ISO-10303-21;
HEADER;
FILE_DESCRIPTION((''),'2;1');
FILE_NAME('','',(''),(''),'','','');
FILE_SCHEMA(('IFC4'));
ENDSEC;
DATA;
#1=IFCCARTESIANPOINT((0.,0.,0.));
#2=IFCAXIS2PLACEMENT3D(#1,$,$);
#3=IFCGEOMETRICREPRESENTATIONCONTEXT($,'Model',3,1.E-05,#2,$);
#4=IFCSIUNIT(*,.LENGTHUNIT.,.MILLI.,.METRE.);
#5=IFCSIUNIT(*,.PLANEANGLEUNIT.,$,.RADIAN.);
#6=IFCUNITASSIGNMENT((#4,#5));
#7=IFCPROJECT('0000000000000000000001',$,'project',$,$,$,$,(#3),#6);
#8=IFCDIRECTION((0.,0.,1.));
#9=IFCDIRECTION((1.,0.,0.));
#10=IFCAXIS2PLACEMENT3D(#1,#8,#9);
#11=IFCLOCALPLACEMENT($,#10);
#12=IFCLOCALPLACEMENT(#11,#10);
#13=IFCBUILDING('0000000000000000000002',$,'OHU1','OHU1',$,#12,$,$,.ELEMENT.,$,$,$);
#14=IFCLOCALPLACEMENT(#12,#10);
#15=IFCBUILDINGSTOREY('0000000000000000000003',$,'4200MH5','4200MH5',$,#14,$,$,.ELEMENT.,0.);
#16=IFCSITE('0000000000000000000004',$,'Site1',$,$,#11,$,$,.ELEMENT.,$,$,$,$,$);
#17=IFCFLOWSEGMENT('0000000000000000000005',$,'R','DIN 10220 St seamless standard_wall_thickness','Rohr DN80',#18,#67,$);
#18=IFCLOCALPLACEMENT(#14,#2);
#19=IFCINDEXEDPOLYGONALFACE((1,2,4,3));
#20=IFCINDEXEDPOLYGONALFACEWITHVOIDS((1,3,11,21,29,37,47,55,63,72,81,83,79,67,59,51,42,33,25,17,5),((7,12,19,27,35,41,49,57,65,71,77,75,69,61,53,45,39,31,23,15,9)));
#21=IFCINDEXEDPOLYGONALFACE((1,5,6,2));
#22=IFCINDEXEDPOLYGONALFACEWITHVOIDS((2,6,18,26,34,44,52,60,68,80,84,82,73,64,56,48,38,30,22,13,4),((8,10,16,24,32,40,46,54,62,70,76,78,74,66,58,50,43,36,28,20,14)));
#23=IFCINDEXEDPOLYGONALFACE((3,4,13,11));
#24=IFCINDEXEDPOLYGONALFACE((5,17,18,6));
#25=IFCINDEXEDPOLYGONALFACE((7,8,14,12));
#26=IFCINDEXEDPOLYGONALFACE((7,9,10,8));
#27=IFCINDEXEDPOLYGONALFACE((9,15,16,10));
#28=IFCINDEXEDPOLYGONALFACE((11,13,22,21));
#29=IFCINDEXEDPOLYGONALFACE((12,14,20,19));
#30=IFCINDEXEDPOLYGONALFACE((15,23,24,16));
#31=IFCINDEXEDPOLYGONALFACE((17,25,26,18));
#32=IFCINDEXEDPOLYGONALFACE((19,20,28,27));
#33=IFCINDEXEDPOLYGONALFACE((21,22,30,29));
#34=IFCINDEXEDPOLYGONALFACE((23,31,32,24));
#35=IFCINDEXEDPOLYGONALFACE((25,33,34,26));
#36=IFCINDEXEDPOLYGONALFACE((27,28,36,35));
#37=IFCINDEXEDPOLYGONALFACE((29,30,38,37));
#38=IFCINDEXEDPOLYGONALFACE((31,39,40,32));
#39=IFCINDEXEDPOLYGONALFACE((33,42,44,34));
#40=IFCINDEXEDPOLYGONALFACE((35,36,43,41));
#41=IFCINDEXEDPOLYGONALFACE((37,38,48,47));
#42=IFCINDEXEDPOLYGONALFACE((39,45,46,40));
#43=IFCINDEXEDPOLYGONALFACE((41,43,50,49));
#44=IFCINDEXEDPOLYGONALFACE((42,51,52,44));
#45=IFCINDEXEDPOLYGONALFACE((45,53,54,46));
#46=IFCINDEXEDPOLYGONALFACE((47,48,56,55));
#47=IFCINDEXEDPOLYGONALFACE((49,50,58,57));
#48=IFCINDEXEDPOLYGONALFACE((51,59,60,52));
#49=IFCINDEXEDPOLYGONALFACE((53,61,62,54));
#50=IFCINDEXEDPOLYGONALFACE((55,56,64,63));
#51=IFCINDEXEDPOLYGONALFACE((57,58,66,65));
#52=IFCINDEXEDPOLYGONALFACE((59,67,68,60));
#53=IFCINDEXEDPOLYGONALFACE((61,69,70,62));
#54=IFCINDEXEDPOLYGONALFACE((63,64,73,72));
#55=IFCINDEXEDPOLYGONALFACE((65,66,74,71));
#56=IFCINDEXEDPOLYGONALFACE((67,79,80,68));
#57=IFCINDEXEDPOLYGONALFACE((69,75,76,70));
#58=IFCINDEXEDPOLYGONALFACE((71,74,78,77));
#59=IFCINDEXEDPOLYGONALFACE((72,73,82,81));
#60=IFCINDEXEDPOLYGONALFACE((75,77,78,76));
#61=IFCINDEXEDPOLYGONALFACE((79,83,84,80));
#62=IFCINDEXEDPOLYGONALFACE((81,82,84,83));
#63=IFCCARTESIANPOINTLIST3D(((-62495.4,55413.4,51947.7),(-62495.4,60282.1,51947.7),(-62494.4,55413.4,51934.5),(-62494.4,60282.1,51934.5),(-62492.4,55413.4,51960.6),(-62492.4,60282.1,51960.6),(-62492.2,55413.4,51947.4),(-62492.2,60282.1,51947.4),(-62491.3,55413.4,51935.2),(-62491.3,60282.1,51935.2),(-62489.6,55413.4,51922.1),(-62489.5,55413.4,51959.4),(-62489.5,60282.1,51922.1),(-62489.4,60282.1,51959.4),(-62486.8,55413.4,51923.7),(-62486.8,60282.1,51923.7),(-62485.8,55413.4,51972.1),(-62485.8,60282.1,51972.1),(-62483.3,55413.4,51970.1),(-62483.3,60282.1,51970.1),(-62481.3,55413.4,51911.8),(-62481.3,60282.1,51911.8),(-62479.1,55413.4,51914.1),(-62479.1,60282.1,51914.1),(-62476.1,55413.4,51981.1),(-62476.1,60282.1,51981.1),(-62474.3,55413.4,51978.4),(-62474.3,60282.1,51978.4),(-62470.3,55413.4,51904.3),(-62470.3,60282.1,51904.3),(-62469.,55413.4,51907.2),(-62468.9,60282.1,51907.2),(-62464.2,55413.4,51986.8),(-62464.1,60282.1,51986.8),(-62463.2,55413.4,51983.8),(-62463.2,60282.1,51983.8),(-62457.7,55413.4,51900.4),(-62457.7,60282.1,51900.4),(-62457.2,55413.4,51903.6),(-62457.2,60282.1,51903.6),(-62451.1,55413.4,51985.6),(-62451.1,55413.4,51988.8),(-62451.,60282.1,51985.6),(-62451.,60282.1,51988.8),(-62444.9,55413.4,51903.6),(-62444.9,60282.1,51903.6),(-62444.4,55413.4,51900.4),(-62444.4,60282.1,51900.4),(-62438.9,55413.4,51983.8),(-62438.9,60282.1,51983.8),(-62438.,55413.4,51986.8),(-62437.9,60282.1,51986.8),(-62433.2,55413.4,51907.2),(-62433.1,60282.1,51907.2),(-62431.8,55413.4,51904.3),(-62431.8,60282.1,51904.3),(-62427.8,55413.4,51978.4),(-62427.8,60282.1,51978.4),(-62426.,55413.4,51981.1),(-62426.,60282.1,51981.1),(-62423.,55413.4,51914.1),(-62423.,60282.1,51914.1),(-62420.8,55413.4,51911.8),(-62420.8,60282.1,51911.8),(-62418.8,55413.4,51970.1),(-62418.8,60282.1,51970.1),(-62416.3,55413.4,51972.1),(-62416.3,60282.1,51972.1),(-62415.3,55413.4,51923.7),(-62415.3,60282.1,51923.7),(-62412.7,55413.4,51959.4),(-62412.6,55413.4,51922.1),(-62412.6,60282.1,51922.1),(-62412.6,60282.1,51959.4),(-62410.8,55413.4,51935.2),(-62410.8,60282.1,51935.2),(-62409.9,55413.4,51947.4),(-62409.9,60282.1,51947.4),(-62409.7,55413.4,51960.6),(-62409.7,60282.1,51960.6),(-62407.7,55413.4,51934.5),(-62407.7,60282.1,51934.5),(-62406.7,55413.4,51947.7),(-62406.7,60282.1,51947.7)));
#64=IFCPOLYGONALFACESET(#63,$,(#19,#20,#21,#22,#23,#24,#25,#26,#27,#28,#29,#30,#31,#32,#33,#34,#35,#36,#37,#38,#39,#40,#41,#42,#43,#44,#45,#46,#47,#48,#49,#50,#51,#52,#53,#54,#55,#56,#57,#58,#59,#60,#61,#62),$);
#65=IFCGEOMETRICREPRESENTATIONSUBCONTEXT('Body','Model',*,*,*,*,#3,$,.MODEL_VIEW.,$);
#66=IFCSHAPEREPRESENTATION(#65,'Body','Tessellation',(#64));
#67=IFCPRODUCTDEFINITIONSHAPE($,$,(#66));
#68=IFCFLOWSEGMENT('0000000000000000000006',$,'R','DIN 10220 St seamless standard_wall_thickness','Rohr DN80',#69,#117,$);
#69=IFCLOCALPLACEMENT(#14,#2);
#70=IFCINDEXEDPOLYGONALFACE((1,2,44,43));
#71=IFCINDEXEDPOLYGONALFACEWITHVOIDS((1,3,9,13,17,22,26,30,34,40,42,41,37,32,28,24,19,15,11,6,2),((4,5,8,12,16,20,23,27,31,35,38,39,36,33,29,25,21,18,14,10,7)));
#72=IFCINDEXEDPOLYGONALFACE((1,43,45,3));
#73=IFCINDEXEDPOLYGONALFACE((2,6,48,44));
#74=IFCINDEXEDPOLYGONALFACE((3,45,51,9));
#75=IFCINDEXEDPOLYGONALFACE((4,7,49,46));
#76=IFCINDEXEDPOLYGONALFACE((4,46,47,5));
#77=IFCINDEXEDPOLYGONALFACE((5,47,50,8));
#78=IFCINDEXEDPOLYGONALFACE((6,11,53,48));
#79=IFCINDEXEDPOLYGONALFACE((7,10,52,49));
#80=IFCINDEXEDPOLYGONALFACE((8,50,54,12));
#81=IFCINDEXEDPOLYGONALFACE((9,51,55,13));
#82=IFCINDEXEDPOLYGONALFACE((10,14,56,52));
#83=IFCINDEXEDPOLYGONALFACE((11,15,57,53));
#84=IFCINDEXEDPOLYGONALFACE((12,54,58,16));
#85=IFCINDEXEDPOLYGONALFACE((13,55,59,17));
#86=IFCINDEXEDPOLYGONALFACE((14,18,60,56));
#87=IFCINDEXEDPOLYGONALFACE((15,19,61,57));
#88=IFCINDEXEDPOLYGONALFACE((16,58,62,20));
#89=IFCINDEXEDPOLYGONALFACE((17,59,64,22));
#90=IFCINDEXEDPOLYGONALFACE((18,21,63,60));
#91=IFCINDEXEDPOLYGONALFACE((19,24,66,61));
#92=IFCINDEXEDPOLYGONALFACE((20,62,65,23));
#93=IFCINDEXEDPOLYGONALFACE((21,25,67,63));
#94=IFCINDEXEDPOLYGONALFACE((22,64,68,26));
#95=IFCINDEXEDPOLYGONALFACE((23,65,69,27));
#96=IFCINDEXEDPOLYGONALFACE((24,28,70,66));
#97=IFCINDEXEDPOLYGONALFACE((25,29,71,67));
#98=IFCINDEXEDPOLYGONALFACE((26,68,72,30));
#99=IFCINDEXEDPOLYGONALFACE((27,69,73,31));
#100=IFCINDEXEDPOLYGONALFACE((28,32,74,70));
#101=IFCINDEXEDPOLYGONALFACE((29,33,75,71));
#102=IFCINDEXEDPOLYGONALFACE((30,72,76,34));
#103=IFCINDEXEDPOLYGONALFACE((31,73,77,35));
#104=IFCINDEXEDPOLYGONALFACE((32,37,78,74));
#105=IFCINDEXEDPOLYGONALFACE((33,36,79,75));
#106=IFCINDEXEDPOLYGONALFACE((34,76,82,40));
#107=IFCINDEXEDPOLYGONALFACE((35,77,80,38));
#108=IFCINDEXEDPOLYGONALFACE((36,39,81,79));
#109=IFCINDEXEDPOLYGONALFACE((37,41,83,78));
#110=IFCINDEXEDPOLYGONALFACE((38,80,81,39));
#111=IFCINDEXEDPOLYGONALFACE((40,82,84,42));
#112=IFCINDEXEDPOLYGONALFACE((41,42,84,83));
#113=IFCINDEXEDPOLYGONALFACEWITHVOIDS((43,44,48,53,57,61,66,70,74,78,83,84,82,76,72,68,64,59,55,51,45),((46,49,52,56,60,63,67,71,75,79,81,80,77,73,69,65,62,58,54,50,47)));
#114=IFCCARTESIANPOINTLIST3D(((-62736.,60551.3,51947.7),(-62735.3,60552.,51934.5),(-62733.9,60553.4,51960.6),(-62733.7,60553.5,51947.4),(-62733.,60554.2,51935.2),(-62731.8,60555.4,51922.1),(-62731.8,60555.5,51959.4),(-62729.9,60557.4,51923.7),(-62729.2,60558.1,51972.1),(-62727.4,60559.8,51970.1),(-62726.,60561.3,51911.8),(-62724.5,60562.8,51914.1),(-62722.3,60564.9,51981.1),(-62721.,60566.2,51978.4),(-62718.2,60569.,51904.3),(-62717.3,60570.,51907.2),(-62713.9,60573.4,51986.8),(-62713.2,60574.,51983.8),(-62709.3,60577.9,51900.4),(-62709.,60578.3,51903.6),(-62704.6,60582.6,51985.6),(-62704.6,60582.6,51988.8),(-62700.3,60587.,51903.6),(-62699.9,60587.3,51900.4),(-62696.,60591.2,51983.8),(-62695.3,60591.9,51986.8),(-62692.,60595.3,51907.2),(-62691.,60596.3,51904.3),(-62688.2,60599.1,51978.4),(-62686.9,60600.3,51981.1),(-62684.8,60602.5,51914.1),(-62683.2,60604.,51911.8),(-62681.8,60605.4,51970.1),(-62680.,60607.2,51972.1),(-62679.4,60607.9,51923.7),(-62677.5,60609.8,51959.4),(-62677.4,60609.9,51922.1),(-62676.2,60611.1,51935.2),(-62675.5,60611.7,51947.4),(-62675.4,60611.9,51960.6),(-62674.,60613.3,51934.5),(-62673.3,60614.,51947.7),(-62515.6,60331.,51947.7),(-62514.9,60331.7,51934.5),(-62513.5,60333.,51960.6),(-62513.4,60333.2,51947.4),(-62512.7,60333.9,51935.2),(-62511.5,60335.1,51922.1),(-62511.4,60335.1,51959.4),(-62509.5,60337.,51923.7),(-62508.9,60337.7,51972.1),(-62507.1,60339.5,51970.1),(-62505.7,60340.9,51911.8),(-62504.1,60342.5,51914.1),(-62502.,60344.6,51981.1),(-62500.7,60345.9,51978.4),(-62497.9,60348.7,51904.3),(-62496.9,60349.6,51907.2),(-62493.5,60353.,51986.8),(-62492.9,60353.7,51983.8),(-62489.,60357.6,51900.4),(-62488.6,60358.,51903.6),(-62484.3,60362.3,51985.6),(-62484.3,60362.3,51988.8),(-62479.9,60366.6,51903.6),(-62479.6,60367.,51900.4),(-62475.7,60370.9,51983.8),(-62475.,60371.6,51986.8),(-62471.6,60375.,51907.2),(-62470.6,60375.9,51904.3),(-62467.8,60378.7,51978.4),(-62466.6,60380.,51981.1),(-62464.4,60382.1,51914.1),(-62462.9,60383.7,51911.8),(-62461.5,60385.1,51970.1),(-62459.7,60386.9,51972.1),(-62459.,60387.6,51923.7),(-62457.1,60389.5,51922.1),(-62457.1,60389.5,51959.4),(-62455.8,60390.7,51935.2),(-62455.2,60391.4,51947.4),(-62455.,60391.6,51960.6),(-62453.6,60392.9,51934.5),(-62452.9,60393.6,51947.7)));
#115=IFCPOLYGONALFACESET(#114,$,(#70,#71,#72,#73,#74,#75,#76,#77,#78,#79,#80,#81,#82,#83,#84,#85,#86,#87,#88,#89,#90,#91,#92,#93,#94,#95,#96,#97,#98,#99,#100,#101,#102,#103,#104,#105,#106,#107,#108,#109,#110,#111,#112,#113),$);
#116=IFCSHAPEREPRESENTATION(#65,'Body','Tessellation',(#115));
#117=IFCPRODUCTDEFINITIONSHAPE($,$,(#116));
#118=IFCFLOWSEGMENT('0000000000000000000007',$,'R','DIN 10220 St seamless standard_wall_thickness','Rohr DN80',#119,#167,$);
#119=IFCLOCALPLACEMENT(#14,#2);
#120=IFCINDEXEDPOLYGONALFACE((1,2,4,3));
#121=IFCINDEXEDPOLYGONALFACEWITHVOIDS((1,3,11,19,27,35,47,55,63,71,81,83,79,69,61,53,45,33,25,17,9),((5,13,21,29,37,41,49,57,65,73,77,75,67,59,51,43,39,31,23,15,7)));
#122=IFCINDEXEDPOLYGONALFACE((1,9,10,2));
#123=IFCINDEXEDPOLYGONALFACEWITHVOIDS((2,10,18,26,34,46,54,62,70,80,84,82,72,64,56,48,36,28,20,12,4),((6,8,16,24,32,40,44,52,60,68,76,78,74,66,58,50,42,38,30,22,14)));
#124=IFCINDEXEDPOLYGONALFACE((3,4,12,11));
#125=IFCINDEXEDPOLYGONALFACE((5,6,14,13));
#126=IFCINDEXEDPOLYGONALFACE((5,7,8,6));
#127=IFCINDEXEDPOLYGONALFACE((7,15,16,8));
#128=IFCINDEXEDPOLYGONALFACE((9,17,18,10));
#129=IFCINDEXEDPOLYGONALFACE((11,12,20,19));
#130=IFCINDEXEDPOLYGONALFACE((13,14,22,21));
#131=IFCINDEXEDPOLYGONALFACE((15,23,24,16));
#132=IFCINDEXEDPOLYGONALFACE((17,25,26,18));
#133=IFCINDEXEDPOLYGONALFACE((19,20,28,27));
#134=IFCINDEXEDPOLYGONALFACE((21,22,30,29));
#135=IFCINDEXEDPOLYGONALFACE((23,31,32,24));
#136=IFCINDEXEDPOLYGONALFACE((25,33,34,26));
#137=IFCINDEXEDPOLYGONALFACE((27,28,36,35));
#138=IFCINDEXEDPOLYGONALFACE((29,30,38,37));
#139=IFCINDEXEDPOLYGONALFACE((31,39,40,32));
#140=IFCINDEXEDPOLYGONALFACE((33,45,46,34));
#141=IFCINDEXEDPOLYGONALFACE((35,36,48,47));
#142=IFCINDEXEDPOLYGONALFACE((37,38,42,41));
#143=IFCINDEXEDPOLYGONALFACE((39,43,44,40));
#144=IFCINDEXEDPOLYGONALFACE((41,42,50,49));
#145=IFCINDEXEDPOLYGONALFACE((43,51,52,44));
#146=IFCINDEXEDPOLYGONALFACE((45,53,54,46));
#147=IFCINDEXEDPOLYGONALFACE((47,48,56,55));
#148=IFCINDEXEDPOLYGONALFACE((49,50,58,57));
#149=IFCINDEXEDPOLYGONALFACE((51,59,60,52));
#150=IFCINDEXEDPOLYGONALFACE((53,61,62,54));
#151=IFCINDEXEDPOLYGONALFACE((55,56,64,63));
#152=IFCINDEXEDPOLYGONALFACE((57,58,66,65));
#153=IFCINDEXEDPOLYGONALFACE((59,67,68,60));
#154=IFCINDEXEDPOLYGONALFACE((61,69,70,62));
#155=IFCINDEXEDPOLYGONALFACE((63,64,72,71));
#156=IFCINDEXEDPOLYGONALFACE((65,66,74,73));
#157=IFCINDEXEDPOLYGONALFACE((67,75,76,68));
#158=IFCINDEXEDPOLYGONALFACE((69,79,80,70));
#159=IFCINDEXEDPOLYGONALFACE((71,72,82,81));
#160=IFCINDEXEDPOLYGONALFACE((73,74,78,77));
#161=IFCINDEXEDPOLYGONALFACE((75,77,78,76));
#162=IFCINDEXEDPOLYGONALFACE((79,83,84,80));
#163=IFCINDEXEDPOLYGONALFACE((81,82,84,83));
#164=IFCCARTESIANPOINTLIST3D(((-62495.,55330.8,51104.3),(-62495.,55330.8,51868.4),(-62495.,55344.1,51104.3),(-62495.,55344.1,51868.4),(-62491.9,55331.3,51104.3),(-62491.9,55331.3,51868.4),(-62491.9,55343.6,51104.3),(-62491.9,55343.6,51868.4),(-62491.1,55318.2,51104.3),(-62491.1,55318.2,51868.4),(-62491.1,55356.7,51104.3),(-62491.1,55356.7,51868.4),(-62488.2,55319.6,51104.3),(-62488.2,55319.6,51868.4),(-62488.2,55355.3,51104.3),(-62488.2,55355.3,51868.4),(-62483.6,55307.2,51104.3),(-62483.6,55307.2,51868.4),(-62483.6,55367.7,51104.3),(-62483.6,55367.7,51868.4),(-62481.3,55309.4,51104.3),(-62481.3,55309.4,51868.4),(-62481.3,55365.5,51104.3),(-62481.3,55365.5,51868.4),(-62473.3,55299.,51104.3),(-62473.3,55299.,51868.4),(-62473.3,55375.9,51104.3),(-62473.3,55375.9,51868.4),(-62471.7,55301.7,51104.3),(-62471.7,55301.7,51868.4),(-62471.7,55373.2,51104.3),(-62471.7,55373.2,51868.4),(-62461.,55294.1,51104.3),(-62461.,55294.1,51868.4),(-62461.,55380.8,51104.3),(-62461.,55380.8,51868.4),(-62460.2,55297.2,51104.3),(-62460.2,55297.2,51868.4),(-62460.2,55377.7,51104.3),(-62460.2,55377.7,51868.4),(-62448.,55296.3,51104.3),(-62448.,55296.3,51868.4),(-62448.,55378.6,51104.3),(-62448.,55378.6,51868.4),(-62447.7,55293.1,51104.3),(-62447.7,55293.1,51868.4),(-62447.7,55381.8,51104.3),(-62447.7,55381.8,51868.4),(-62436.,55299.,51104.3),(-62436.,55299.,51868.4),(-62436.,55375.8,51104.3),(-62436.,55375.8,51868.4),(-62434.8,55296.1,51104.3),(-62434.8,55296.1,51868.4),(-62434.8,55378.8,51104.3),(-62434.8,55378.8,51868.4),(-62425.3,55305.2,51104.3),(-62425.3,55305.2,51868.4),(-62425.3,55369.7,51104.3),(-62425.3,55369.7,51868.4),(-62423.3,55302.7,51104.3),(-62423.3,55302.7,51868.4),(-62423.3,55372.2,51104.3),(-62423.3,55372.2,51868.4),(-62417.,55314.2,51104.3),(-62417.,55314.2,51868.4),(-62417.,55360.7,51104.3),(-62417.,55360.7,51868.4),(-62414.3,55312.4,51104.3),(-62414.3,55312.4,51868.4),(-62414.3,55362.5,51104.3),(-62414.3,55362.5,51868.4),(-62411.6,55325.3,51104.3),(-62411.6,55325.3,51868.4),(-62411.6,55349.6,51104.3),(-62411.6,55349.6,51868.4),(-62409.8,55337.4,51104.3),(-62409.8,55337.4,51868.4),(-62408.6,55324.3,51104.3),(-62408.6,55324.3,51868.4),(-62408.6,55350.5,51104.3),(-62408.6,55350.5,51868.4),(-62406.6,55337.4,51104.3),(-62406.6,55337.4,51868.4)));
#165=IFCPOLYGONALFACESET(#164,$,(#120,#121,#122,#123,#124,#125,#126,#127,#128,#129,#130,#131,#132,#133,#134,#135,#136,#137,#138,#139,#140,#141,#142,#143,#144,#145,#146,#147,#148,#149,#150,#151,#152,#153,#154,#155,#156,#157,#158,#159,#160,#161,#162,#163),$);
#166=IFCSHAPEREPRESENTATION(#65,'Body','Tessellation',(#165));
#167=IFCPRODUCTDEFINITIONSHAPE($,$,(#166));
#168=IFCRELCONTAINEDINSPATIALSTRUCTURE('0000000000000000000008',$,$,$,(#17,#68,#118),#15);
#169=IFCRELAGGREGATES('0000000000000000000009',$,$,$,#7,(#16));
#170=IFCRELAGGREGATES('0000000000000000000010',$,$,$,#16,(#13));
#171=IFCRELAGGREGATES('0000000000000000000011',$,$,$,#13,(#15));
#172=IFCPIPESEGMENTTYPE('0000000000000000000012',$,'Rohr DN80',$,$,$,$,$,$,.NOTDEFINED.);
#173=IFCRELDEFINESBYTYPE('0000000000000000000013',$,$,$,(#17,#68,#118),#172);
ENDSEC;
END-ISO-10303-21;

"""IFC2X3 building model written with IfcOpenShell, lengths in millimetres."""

from ifc_helpers import new_model, si_unit, frame, origin, origin_with_axes, origin_2d_with_axis, place, context, subcontext, project, spatial, hollow_circle, extrude, type_object, element, save


model = new_model("IFC2X3")

# Units and contexts
model_context = context("Model", 3, precision=1e-05, world=origin())
body_context = subcontext(model_context, "Body", "Model", "MODEL_VIEW")
ifc_project = project(units=[si_unit("LENGTHUNIT", "METRE", prefix="MILLI"), si_unit("PLANEANGLEUNIT", "RADIAN")], contexts=[model_context])

# Site, building, storey
site_placement = place(None, origin_with_axes())
site = spatial("IfcSite", under=ifc_project, at=site_placement, Name="Site1", CompositionType="ELEMENT")
building_placement = place(site_placement, origin_with_axes())
building = spatial("IfcBuilding", under=site, at=building_placement, Name="OHU1", Description="OHU1", CompositionType="ELEMENT")
storey_placement = place(building_placement, origin_with_axes())
storey = spatial("IfcBuildingStorey", under=building, at=storey_placement, Name="4200MH5", Description="4200MH5", CompositionType="ELEMENT", Elevation=0.0)

# Flow segments
pipe_segment_type_1 = type_object("IfcPipeSegmentType", Name="Rohr DN80", PredefinedType="NOTDEFINED")
flow_segment_1_placement = place(storey_placement, frame((-62451.1, 57847.8, 51944.4), z_axis=(0.0, 0.0, 1.0), x_axis=(1.0, 0.0, 0.0)))
element("IfcFlowSegment", 1, at=flow_segment_1_placement, inside=storey, type_object=pipe_segment_type_1, Name="R", Description="DIN 10220 St seamless standard_wall_thickness", ObjectType="Rohr DN80", context=body_context, shape_type="SweptSolid", body=[
    extrude(hollow_circle(Radius=44.5, WallThickness=3.2, at=origin_2d_with_axis()), frame((0.0, -2434.3, 0.0), z_axis=(0.000003, 1.0, 0.0), x_axis=(0.0, 0.0, 1.0)), (0.0, 0.0, 1.0), 4868.6),
])
flow_segment_2_placement = place(storey_placement, frame((-62594.4, 60472.5, 51944.4), z_axis=(0.0, 0.0, 1.0), x_axis=(1.0, 0.0, 0.0)))
element("IfcFlowSegment", 2, at=flow_segment_2_placement, inside=storey, type_object=pipe_segment_type_1, Name="R", Description="DIN 10220 St seamless standard_wall_thickness", ObjectType="Rohr DN80", context=body_context, shape_type="SweptSolid", body=[
    extrude(hollow_circle(Radius=44.5, WallThickness=3.2, at=origin_2d_with_axis()), frame((-110.2, 110.2, 0.0), z_axis=(0.707104, -0.707109, 0.0), x_axis=(0.0, 0.0, 1.0)), (0.0, 0.0, 1.0), 311.6),
])
flow_segment_3_placement = place(storey_placement, frame((-62451.1, 55337.4, 51486.3), z_axis=(0.0, 0.0, 1.0), x_axis=(1.0, 0.0, 0.0)))
element("IfcFlowSegment", 3, at=flow_segment_3_placement, inside=storey, type_object=pipe_segment_type_1, Name="R", Description="DIN 10220 St seamless standard_wall_thickness", ObjectType="Rohr DN80", context=body_context, shape_type="SweptSolid", body=[
    extrude(hollow_circle(Radius=44.5, WallThickness=3.2, at=origin_2d_with_axis()), frame((0.0, 0.0, 382.1), z_axis=(0.0, 0.0, -1.0), x_axis=(1.0, 0.0, 0.0)), (0.0, 0.0, 1.0), 764.1),
])

save(model, "model.ifc")
